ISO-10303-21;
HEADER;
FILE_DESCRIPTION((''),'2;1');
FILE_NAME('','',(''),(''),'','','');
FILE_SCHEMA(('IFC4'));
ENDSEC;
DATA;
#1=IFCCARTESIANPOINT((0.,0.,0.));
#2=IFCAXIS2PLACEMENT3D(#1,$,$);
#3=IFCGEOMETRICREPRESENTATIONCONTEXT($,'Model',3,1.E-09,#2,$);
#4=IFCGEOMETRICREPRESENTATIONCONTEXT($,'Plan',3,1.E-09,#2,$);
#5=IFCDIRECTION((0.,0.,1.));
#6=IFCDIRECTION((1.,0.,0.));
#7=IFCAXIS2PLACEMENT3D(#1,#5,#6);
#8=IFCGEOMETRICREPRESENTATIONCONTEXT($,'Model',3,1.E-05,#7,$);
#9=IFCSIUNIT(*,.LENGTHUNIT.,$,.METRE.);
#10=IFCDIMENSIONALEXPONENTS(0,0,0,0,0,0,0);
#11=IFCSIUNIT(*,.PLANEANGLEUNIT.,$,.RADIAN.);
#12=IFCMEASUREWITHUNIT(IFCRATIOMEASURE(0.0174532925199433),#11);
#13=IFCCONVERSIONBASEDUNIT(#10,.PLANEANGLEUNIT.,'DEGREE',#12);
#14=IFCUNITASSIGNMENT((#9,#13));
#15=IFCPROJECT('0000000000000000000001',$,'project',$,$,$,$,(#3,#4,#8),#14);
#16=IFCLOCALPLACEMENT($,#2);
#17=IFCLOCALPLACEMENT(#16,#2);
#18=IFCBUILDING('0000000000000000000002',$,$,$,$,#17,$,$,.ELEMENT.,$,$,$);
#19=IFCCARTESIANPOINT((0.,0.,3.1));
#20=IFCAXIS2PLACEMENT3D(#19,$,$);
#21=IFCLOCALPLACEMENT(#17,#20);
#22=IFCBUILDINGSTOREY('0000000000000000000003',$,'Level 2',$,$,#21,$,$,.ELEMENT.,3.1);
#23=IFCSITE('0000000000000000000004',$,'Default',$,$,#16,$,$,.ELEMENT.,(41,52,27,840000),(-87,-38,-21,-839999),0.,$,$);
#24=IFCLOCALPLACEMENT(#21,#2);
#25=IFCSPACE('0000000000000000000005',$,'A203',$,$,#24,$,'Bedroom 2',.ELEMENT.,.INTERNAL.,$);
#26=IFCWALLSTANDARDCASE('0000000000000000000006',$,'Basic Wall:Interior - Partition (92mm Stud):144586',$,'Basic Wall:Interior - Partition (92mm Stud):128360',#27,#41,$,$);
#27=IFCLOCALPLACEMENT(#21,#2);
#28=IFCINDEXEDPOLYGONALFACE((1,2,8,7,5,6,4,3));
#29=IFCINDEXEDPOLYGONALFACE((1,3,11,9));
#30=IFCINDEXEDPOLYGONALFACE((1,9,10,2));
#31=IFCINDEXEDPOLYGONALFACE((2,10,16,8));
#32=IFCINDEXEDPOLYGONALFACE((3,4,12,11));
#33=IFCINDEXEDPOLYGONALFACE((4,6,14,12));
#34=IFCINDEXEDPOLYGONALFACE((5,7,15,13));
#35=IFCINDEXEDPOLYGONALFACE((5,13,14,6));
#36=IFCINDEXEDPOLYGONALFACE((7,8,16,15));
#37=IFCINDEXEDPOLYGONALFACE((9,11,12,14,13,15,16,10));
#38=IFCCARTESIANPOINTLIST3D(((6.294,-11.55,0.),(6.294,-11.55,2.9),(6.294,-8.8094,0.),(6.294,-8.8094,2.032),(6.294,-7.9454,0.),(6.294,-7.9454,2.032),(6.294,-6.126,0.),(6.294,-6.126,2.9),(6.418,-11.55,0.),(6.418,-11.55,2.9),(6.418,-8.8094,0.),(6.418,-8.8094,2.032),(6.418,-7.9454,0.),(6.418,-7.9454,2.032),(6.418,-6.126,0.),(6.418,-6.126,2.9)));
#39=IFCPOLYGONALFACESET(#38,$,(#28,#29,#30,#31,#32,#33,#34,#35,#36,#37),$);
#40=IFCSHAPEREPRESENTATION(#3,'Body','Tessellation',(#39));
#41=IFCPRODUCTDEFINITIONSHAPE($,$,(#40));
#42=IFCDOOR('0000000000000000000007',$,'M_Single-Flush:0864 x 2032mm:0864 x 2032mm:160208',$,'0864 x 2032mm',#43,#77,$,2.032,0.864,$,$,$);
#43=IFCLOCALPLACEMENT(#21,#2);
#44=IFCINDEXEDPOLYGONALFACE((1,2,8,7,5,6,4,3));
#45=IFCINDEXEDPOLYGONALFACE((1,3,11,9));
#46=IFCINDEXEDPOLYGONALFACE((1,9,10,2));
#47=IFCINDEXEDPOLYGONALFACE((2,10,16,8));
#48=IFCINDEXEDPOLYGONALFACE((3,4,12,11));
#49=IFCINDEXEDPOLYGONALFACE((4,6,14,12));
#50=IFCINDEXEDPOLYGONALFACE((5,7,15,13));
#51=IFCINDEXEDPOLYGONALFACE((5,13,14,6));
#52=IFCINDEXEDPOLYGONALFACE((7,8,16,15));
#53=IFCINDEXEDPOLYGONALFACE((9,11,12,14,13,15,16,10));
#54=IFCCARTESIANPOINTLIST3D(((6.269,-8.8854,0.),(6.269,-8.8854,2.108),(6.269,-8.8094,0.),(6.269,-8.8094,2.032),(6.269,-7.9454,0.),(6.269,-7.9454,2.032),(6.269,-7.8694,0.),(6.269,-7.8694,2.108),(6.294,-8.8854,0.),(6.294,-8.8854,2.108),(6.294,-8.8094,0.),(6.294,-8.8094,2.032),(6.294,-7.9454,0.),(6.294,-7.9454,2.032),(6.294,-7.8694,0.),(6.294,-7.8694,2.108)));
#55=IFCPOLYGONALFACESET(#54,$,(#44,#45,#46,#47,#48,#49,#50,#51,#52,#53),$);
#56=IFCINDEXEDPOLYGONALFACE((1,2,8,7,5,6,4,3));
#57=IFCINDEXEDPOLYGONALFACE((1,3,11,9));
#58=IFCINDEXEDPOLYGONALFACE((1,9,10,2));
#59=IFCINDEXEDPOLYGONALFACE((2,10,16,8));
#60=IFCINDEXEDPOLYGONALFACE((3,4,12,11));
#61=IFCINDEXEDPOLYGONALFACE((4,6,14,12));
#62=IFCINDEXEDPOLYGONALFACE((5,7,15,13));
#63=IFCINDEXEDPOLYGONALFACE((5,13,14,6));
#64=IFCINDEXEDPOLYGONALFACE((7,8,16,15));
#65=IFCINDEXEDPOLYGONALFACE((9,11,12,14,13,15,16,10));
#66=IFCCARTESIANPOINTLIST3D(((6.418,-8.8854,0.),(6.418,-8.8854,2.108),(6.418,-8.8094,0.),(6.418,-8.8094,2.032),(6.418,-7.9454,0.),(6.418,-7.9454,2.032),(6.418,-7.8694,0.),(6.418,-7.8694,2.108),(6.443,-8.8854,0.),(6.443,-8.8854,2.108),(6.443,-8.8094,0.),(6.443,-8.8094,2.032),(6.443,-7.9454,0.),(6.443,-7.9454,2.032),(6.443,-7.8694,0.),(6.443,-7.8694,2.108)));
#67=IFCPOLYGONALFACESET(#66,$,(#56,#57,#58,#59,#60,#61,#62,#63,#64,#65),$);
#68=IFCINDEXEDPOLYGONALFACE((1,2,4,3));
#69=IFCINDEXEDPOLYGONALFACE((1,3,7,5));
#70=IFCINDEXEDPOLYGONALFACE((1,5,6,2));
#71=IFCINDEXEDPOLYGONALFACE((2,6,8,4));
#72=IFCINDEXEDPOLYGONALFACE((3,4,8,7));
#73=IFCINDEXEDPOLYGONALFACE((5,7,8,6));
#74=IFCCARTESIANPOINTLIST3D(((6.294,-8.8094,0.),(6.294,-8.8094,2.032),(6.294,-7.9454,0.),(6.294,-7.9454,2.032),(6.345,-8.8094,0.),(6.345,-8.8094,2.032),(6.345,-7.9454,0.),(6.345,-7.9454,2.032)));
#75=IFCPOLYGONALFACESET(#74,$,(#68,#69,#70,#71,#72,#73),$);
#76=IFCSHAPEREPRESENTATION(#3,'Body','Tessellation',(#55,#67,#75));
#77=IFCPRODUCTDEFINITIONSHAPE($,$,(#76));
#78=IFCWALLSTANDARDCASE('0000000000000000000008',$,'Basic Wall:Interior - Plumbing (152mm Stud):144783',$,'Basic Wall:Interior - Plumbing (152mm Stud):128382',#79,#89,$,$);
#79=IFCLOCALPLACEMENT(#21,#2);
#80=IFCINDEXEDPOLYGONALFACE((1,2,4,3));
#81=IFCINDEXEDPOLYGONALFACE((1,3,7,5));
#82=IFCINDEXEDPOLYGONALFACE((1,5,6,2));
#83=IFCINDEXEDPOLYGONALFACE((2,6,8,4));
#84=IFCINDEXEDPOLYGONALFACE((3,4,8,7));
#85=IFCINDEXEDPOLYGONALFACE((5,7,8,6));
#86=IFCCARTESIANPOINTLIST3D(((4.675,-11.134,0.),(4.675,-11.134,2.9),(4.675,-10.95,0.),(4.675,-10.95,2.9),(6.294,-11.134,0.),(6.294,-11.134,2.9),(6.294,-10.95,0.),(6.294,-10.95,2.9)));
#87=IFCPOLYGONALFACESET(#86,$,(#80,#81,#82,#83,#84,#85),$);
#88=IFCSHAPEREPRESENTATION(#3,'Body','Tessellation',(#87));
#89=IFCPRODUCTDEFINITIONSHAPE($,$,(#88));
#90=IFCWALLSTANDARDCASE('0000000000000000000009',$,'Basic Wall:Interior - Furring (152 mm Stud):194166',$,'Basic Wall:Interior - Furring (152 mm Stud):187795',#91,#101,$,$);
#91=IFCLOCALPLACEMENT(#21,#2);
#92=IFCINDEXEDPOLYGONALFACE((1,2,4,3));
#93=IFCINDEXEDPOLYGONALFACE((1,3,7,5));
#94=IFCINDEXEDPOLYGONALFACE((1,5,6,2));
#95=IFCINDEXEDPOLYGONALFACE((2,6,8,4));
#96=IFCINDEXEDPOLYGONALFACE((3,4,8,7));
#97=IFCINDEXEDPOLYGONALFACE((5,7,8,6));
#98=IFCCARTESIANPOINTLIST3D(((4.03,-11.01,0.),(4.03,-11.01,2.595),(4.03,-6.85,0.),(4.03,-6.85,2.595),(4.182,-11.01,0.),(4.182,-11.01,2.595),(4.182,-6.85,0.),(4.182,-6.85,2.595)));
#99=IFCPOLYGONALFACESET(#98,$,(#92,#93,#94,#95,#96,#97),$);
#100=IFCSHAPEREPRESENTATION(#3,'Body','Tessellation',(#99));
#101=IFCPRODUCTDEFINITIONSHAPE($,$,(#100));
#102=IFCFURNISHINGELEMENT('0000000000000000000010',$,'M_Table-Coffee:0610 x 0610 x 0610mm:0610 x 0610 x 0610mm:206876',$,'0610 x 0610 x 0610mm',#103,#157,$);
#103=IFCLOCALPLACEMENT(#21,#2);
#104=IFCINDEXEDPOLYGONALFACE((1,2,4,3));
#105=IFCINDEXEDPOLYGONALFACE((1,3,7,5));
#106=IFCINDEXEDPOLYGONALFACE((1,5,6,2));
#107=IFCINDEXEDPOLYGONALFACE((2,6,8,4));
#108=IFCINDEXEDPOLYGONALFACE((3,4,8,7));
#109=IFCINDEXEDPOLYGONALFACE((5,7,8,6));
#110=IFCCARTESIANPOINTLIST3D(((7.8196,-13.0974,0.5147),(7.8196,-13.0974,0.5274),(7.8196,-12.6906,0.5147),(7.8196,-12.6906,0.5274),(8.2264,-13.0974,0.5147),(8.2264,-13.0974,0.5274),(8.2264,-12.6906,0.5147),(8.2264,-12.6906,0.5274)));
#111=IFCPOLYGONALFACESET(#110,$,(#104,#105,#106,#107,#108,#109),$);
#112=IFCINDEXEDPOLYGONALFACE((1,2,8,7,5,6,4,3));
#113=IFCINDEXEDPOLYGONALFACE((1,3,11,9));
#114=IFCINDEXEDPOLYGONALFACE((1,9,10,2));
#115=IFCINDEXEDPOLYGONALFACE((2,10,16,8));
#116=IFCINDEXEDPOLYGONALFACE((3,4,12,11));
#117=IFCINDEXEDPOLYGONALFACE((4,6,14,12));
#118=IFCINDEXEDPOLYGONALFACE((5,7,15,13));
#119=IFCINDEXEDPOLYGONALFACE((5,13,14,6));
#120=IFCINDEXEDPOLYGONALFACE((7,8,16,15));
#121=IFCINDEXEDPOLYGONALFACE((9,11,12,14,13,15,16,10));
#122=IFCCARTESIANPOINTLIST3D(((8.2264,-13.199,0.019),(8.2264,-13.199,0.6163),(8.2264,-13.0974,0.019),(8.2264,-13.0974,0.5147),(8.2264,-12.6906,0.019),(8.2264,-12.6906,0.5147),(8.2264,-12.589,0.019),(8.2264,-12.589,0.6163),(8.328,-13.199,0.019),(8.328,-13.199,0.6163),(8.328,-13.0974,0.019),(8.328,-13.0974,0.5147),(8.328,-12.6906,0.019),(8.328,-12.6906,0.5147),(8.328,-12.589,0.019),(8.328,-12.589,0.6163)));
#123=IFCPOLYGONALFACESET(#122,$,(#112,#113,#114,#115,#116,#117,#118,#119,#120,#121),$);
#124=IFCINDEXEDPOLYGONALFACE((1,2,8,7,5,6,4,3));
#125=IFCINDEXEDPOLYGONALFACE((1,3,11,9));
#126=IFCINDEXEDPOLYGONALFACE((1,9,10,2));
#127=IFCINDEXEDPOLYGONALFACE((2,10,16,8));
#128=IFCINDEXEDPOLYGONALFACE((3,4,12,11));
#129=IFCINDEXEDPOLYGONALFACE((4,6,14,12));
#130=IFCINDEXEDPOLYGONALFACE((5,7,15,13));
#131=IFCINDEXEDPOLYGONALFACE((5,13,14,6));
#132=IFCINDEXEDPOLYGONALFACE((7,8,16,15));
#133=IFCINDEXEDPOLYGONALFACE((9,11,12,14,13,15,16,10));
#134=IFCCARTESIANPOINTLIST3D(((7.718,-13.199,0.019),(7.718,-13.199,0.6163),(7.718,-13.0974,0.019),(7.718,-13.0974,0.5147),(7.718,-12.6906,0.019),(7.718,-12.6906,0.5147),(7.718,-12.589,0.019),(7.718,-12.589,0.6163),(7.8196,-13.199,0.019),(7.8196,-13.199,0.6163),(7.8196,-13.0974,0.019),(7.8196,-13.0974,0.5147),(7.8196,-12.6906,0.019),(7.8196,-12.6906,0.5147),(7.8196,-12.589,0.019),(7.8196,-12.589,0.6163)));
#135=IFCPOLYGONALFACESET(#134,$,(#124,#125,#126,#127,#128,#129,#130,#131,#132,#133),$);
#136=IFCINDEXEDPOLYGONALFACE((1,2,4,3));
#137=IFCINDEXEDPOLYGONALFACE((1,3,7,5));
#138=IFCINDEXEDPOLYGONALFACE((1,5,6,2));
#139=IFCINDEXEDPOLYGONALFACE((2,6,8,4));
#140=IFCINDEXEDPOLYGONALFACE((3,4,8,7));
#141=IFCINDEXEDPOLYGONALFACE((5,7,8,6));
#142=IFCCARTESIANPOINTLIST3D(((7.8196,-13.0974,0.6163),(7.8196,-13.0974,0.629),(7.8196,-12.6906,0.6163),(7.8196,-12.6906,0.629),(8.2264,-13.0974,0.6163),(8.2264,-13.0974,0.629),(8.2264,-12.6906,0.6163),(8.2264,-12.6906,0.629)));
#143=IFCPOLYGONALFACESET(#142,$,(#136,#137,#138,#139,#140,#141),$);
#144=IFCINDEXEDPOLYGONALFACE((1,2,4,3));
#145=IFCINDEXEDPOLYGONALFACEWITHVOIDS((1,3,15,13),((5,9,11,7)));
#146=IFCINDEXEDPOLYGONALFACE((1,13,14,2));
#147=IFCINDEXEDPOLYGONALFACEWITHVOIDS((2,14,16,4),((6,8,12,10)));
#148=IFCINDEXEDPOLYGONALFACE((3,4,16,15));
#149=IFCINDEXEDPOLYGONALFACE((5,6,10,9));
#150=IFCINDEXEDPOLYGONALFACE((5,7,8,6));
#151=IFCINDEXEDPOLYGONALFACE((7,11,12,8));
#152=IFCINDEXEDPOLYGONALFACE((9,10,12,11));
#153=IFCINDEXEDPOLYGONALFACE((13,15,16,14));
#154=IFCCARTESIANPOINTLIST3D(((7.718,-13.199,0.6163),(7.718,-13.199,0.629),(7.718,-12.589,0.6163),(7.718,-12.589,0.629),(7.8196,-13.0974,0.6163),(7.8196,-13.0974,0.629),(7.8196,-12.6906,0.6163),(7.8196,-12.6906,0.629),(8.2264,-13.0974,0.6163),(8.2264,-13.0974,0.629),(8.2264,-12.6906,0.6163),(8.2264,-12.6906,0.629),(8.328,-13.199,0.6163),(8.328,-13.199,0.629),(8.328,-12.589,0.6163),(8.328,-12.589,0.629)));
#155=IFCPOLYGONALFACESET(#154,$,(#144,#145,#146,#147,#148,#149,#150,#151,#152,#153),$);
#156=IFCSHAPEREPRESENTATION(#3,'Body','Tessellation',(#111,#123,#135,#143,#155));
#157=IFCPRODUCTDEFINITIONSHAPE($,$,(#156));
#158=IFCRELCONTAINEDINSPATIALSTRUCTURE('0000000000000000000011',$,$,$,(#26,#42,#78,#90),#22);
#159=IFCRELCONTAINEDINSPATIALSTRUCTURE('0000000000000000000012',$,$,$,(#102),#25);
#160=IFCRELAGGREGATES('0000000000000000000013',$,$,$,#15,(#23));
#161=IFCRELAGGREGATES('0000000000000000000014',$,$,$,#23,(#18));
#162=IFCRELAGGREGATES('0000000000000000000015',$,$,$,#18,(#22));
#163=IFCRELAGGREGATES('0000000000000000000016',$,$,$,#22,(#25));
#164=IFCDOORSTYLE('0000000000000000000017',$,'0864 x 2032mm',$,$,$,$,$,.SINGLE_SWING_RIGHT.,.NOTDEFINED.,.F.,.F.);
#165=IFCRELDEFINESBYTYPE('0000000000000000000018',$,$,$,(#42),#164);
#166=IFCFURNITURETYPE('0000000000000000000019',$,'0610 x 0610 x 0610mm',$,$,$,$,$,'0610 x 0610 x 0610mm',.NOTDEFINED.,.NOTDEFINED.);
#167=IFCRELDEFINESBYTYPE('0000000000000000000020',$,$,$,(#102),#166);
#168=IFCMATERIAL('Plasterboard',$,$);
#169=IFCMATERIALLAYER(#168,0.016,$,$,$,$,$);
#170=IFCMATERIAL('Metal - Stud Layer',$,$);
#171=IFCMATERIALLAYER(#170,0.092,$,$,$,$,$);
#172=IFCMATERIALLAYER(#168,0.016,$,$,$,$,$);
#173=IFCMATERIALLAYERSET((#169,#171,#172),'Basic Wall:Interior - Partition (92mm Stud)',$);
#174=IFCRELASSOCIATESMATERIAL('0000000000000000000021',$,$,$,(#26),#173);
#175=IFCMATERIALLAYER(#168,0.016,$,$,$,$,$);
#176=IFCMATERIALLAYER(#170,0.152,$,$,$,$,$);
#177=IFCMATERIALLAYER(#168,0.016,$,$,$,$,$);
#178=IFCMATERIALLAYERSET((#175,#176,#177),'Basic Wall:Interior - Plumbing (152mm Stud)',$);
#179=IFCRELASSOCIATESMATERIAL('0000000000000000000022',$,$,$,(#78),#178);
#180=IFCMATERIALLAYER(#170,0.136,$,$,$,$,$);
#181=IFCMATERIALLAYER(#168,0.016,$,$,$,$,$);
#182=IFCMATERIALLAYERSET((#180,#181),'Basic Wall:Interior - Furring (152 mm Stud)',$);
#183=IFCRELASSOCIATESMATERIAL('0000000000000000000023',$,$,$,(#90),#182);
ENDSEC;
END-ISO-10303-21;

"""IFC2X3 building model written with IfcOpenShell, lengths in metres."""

from ifc_helpers import new_model, entity, si_unit, converted_unit, frame, frame_2d, origin, origin_with_axes, origin_2d_with_axis, place, context, project, spatial, polyline, rectangle, outline, extrude, source, transform, mapped, material, layer, layer_set, layer_usage, type_object, type_shapes, element, fill, save


model = new_model("IFC2X3")

# Units and contexts
model_context_1 = context("Model", 3, precision=1e-09, world=origin())
plan_context = context("Plan", 3, precision=1e-09, world=origin())
model_context_2 = context("Model", 3, precision=1e-05, world=origin_with_axes())
ifc_project = project(units=[si_unit("LENGTHUNIT", "METRE"), converted_unit("PLANEANGLEUNIT", "DEGREE", entity("IfcRatioMeasure", 0.0174532925199433), si_unit("PLANEANGLEUNIT", "RADIAN"), dimensions=[0, 0, 0, 0, 0, 0, 0])], contexts=[model_context_1, plan_context, model_context_2])

# Site, building, storey
site_placement = place(None, origin())
site = spatial("IfcSite", under=ifc_project, at=site_placement, Name="Default", CompositionType="ELEMENT", RefLatitude=(41, 52, 27, 840000), RefLongitude=(-87, -38, -21, -839999), RefElevation=0.0)
building_placement = place(site_placement, origin())
building = spatial("IfcBuilding", under=site, at=building_placement, CompositionType="ELEMENT")
storey_placement = place(building_placement, frame((0.0, 0.0, 3.1)))
storey = spatial("IfcBuildingStorey", under=building, at=storey_placement, Name="Level 2", CompositionType="ELEMENT", Elevation=3.1)

# Shared definitions
ifc_material_1 = material(Name="Metal - Stud Layer")
ifc_material_2 = material(Name="Plasterboard")

# Shared definitions
ifc_layer_1 = layer(ifc_material_2, 0.016)
ifc_layer_2 = layer(ifc_material_1, 0.092)
ifc_layer_3 = layer(ifc_material_2, 0.016)
ifc_layer_set_1 = layer_set([ifc_layer_1, ifc_layer_2, ifc_layer_3], Name="Basic Wall:Interior - Partition (92mm Stud)")

# Wall, opening, door
ifc_layer_usage_1 = layer_usage(ifc_layer_set_1, "AXIS2", "NEGATIVE", 0.062)
wall_1_placement = place(storey_placement, frame((6.356, -11.55, 0.0), z_axis=(0.0, 0.0, 1.0), x_axis=(0.0, 1.0, 0.0)))
wall_1 = element("IfcWallStandardCase", 1, at=wall_1_placement, inside=storey, material=ifc_layer_usage_1, Name="Basic Wall:Interior - Partition (92mm Stud):144586", ObjectType="Basic Wall:Interior - Partition (92mm Stud):128360", context=model_context_1, shape_type="SweptSolid", body=[
    extrude(rectangle(XDim=5.424, YDim=0.124, at=frame_2d((2.712, 0.0), x_axis=(-1.0, 0.0))), origin(), (0.0, 0.0, 1.0), 2.9),
])
opening_1_placement = place(wall_1_placement, frame((2.7406, -0.062, 0.0)))
opening_1 = element("IfcOpeningElement", 2, at=opening_1_placement, cuts=wall_1, ObjectType="Opening", context=model_context_1, shape_type="SweptSolid", body=[
    extrude(rectangle(XDim=0.864, YDim=2.032, at=frame_2d((1.016, 0.432), x_axis=(0.0, 1.0))), frame((0.0, 0.0, 0.0), z_axis=(0.0, 1.0, 0.0), x_axis=(0.0, 0.0, 1.0)), (0.0, 0.0, 1.0), 0.124),
])
door_style = type_object("IfcDoorStyle", Name="0864 x 2032mm", ConstructionType="NOTDEFINED", OperationType="SINGLE_SWING_RIGHT", ParameterTakesPrecedence=False, Sizeable=False)
shared_shape_1 = source(origin(), model_context_1, "Body", "SweptSolid", [
    extrude(outline(polyline([(-0.508, -1.073), (0.508, -1.073), (0.508, 1.035), (0.432, 1.035), (0.432, -0.997), (-0.432, -0.997), (-0.432, 1.035), (-0.508, 1.035), (-0.508, -1.073)])), frame((0.432, 0.124, 1.035), z_axis=(0.0, 1.0, 0.0), x_axis=(1.0, 0.0, 0.0)), (0.0, 0.0, 1.0), 0.025),
    extrude(outline(polyline([(-1.073, -0.508), (1.035, -0.508), (1.035, -0.432), (-0.997, -0.432), (-0.997, 0.432), (1.035, 0.432), (1.035, 0.508), (-1.073, 0.508), (-1.073, -0.508)])), frame((0.432, -0.025, 1.035), z_axis=(0.0, 1.0, 0.0), x_axis=(0.0, 0.0, -1.0)), (0.0, 0.0, 1.0), 0.025),
    extrude(rectangle(XDim=0.051, YDim=0.864, at=origin_2d_with_axis()), frame((0.432, 0.0985, 0.0), z_axis=(0.0, 0.0, 1.0), x_axis=(0.0, 1.0, 0.0)), (0.0, 0.0, 1.0), 2.032),
])
type_shapes(door_style, [shared_shape_1])
door_placement = place(opening_1_placement, origin())
door = element("IfcDoor", 3, at=door_placement, inside=storey, type_object=door_style, Name="M_Single-Flush:0864 x 2032mm:0864 x 2032mm:160208", ObjectType="0864 x 2032mm", OverallHeight=2.032, OverallWidth=0.864, context=model_context_1, shape_type="MappedRepresentation", body=[
    mapped(shared_shape_1, transform((0.0, 0.0, 0.0), scale=1.0)),
])
fill(opening_1, door)

# Walls
ifc_layer_4 = layer(ifc_material_2, 0.016)
ifc_layer_5 = layer(ifc_material_1, 0.152)
ifc_layer_6 = layer(ifc_material_2, 0.016)
ifc_layer_set_2 = layer_set([ifc_layer_4, ifc_layer_5, ifc_layer_6], Name="Basic Wall:Interior - Plumbing (152mm Stud)")
ifc_layer_usage_2 = layer_usage(ifc_layer_set_2, "AXIS2", "NEGATIVE", 0.092)
wall_2_placement = place(storey_placement, frame((6.294, -11.042, 0.0), z_axis=(0.0, 0.0, 1.0), x_axis=(-1.0, 0.0, 0.0)))
element("IfcWallStandardCase", 4, at=wall_2_placement, inside=storey, material=ifc_layer_usage_2, Name="Basic Wall:Interior - Plumbing (152mm Stud):144783", ObjectType="Basic Wall:Interior - Plumbing (152mm Stud):128382", context=model_context_1, shape_type="SweptSolid", body=[
    extrude(rectangle(XDim=1.619, YDim=0.184, at=frame_2d((0.8095, 0.0), x_axis=(-1.0, 0.0))), origin(), (0.0, 0.0, 1.0), 2.9),
])
ifc_layer_7 = layer(ifc_material_1, 0.136)
ifc_layer_8 = layer(ifc_material_2, 0.016)
ifc_layer_set_3 = layer_set([ifc_layer_7, ifc_layer_8], Name="Basic Wall:Interior - Furring (152 mm Stud)")
ifc_layer_usage_3 = layer_usage(ifc_layer_set_3, "AXIS2", "POSITIVE", -0.076)
wall_3_placement = place(storey_placement, frame((4.106, -11.01, 0.0), z_axis=(0.0, 0.0, 1.0), x_axis=(0.0, 1.0, 0.0)))
element("IfcWallStandardCase", 5, at=wall_3_placement, inside=storey, material=ifc_layer_usage_3, Name="Basic Wall:Interior - Furring (152 mm Stud):194166", ObjectType="Basic Wall:Interior - Furring (152 mm Stud):187795", context=model_context_1, shape_type="SweptSolid", body=[
    extrude(rectangle(XDim=4.16, YDim=0.152, at=frame_2d((2.08, 0.0), x_axis=(-1.0, 0.0))), origin(), (0.0, 0.0, 1.0), 2.595),
])

# Shared definitions
space_placement = place(storey_placement, origin())
space = spatial("IfcSpace", under=storey, at=space_placement, Name="A203", LongName="Bedroom 2", CompositionType="ELEMENT", InteriorOrExteriorSpace="INTERNAL")

# Furnishing element
furniture_type = type_object("IfcFurnitureType", Name="0610 x 0610 x 0610mm", ElementType="0610 x 0610 x 0610mm", AssemblyPlace="NOTDEFINED")
shared_shape_2 = source(origin(), model_context_1, "Body", "SweptSolid", [
    extrude(rectangle(XDim=0.4068, YDim=0.4068, at=origin_2d_with_axis()), frame((0.0183, 0.0952, 0.4957), z_axis=(0.0, 0.0, 1.0), x_axis=(-1.0, 0.0, 0.0)), (0.0, 0.0, 1.0), 0.0127),
    extrude(outline(polyline([(-0.2732, -0.305), (0.324, -0.305), (0.324, 0.305), (-0.2732, 0.305), (-0.2732, 0.2034), (0.2225, 0.2034), (0.2225, -0.2034), (-0.2732, -0.2034), (-0.2732, -0.305)])), frame((0.2217, 0.0952, 0.2732), z_axis=(1.0, 0.0, 0.0), x_axis=(0.0, 0.0, 1.0)), (0.0, 0.0, 1.0), 0.1016),
    extrude(outline(polyline([(-0.305, -0.3241), (0.305, -0.3241), (0.305, 0.2733), (0.2034, 0.2733), (0.2034, -0.2224), (-0.2034, -0.2224), (-0.2034, 0.2733), (-0.305, 0.2733), (-0.305, -0.3241)])), frame((-0.2867, 0.0952, 0.2733), z_axis=(1.0, 0.0, 0.0), x_axis=(0.0, -1.0, 0.0)), (0.0, 0.0, 1.0), 0.1016),
    extrude(rectangle(XDim=0.4068, YDim=0.4068, at=origin_2d_with_axis()), frame((0.0183, 0.0952, 0.5973), z_axis=(0.0, 0.0, 1.0), x_axis=(-1.0, 0.0, 0.0)), (0.0, 0.0, 1.0), 0.0127),
    extrude(outline(polyline([(-0.305, -0.305), (0.305, -0.305), (0.305, 0.305), (-0.305, 0.305), (-0.305, -0.305)]), holes=[polyline([(-0.2034, -0.2034), (-0.2034, 0.2034), (0.2034, 0.2034), (0.2034, -0.2034), (-0.2034, -0.2034)])]), frame((0.0183, 0.0952, 0.5973), z_axis=(0.0, 0.0, 1.0), x_axis=(-1.0, 0.0, 0.0)), (0.0, 0.0, 1.0), 0.0127),
])
type_shapes(furniture_type, [shared_shape_2])
furnishing_placement = place(space_placement, frame((8.0047, -12.9892, 0.019)))
element("IfcFurnishingElement", 6, at=furnishing_placement, inside=space, type_object=furniture_type, Name="M_Table-Coffee:0610 x 0610 x 0610mm:0610 x 0610 x 0610mm:206876", ObjectType="0610 x 0610 x 0610mm", context=model_context_1, shape_type="MappedRepresentation", body=[
    mapped(shared_shape_2, transform((0.0, 0.0, 0.0), scale=1.0)),
])

save(model, "model.ifc")
